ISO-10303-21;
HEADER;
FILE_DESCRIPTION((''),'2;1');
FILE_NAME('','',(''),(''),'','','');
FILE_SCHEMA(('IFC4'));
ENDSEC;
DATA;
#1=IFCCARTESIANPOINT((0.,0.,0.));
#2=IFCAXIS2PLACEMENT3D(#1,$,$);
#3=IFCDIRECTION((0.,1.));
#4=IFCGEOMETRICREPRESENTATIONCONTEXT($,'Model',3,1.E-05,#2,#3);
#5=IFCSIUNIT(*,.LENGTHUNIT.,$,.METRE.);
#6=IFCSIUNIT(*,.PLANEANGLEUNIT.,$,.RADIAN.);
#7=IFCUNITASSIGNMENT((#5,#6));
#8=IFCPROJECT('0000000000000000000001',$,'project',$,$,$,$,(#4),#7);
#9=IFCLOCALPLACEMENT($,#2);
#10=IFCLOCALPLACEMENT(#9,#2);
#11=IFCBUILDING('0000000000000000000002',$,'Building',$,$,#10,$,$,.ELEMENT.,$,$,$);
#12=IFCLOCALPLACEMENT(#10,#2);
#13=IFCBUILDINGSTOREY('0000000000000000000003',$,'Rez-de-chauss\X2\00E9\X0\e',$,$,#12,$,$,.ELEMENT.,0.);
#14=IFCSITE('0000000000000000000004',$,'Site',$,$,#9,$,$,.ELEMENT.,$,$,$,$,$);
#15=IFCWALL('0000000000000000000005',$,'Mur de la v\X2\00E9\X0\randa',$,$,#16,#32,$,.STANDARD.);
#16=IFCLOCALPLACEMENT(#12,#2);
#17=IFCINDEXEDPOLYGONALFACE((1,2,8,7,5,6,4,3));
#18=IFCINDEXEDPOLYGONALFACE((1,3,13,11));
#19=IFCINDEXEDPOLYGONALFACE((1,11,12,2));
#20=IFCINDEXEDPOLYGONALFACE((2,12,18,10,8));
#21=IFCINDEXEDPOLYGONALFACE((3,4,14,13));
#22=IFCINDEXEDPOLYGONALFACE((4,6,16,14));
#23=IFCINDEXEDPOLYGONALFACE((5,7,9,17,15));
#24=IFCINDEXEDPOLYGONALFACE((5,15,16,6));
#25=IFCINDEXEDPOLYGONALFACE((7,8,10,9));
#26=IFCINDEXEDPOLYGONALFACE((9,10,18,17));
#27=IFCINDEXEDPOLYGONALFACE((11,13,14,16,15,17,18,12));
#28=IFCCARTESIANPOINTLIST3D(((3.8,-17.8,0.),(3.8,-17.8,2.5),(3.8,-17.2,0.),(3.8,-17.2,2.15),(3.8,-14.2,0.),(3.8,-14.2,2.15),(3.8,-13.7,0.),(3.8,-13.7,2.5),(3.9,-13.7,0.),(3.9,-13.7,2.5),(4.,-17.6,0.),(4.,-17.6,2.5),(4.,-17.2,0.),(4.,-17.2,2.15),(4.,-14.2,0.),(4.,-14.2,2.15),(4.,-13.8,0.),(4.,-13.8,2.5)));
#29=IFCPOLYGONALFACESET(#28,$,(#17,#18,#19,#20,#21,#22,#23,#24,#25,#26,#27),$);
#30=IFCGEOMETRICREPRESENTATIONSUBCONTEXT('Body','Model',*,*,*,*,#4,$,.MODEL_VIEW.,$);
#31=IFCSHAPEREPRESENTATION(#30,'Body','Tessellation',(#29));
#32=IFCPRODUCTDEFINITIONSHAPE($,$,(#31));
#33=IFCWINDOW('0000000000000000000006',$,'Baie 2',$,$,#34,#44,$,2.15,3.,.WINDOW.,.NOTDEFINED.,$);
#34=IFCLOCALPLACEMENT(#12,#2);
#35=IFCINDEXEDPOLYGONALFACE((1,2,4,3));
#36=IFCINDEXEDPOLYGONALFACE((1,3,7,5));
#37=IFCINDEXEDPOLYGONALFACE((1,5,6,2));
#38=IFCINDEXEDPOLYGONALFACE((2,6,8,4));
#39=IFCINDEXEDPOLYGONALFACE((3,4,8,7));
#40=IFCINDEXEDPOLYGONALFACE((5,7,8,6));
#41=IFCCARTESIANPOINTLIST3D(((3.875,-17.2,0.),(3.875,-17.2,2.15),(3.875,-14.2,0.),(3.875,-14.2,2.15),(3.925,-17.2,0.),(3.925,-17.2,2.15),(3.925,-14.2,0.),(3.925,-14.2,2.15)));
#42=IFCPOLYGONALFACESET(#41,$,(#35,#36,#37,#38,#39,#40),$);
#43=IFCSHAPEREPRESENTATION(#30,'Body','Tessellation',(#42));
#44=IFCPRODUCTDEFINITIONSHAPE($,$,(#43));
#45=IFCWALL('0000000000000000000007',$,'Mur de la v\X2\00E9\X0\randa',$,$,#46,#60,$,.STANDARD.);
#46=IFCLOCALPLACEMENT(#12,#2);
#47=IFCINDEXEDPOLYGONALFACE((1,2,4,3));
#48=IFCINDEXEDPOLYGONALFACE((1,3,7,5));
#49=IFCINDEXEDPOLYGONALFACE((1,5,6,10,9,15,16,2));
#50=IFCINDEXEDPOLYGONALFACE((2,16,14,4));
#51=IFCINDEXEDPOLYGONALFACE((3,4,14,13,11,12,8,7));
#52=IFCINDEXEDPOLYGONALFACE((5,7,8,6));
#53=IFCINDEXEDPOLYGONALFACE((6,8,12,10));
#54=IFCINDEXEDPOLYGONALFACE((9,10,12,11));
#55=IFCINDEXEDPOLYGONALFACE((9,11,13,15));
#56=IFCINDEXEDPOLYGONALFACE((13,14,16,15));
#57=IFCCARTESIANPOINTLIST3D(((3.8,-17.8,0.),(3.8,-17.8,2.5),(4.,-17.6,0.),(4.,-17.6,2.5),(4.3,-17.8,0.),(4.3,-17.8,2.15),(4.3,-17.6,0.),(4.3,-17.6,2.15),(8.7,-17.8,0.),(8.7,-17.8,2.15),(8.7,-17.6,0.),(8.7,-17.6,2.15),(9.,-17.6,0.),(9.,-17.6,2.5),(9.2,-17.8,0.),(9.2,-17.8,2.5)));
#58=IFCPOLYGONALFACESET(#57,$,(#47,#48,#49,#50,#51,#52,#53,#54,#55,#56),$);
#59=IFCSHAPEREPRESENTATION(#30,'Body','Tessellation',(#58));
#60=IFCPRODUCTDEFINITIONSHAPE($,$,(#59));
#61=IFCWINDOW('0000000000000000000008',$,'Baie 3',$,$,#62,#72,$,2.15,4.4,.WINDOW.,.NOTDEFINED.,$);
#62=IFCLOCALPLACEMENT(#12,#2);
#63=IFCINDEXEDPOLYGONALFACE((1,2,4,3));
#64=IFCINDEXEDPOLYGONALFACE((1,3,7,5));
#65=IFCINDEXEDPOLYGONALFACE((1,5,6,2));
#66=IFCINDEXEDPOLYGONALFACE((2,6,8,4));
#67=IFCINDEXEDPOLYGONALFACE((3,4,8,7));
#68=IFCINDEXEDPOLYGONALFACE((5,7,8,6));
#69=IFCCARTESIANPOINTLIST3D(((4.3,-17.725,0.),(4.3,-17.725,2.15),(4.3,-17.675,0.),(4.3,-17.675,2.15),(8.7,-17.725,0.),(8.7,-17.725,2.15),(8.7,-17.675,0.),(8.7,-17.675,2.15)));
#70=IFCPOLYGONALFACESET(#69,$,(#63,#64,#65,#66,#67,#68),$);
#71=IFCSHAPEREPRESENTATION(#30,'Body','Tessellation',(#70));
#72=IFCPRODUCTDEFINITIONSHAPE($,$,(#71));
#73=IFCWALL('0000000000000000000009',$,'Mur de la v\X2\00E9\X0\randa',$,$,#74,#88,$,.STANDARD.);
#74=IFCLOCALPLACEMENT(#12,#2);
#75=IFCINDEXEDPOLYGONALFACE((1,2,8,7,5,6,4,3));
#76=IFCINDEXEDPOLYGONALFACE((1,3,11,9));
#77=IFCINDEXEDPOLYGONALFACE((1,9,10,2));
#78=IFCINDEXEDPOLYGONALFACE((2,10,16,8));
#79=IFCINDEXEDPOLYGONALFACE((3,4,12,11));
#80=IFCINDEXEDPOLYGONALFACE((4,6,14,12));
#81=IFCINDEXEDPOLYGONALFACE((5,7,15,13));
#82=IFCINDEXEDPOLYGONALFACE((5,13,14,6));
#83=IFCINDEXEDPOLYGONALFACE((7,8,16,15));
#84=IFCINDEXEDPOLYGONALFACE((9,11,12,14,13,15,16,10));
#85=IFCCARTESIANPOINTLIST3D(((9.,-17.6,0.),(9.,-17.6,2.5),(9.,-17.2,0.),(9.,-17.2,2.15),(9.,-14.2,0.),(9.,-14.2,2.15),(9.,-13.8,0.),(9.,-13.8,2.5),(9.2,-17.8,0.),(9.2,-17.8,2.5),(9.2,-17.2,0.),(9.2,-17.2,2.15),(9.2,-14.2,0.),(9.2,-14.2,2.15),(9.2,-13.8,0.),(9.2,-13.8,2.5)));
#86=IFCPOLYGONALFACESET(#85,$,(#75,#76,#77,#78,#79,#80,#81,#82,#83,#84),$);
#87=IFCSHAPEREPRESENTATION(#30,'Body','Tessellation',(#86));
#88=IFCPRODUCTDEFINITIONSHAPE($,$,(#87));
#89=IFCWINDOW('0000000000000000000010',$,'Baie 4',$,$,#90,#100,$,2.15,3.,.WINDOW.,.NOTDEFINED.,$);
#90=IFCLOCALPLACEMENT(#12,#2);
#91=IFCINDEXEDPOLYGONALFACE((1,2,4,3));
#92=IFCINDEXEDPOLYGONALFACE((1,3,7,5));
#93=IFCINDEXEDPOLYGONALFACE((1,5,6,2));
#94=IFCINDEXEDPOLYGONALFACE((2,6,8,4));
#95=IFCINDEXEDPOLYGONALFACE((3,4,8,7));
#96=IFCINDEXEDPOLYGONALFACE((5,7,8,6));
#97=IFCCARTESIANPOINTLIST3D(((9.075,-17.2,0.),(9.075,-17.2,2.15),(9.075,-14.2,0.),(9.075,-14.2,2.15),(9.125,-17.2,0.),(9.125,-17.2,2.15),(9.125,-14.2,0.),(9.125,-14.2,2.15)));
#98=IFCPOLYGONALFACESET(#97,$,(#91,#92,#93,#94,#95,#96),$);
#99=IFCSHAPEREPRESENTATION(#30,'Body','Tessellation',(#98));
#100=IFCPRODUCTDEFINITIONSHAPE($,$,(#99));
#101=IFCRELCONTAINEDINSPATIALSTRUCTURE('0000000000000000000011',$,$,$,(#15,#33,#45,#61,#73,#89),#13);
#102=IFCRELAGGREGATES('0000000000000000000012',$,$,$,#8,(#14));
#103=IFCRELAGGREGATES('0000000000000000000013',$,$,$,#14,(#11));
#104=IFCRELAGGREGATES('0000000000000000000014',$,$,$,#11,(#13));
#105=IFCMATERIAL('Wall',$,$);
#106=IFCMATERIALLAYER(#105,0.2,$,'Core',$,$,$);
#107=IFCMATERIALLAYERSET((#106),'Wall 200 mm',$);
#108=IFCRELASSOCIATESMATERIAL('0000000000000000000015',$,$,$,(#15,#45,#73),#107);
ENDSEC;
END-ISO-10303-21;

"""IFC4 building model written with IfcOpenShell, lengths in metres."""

from ifc_helpers import new_model, si_unit, direction, frame, origin, origin_2d, place, context, subcontext, project, spatial, polyline, rectangle, outline, extrude, material, layer, layer_set, layer_usage, element, fill, save


model = new_model("IFC4")

# Units and contexts
model_context = context("Model", 3, precision=1e-05, world=origin(), true_north=direction((0.0, 1.0)))
body_context = subcontext(model_context, "Body", "Model", "MODEL_VIEW")
ifc_project = project(units=[si_unit("LENGTHUNIT", "METRE"), si_unit("PLANEANGLEUNIT", "RADIAN")], contexts=[model_context])

# Site, building, storey
site_placement = place(None, origin())
site = spatial("IfcSite", under=ifc_project, at=site_placement, Name="Site", CompositionType="ELEMENT")
building_placement = place(site_placement, origin())
building = spatial("IfcBuilding", under=site, at=building_placement, Name="Building", CompositionType="ELEMENT")
storey_placement = place(building_placement, origin())
storey = spatial("IfcBuildingStorey", under=building, at=storey_placement, Name="Rez-de-chaussée", CompositionType="ELEMENT", Elevation=0.0)

# Shared definitions
ifc_material = material(Name="Wall")
ifc_layer = layer(ifc_material, 0.2, Name="Core")
ifc_layer_set = layer_set([ifc_layer], Name="Wall 200 mm")
ifc_layer_usage = layer_usage(ifc_layer_set, "AXIS2", "POSITIVE", -0.1)

# Walls, openings, windows
wall_1_placement = place(storey_placement, frame((3.9, -13.7, 0.0), z_axis=(0.0, 0.0, 1.0), x_axis=(0.0, -1.0, 0.0)))
wall_1 = element("IfcWall", 1, at=wall_1_placement, inside=storey, material=ifc_layer_usage, Name="Mur de la véranda", PredefinedType="STANDARD", context=body_context, shape_type="SweptSolid", body=[
    extrude(outline(polyline([(0.0, 0.0), (0.0, -0.1), (4.1, -0.1), (4.0, 0.0), (3.9, 0.1), (0.1, 0.1), (0.0, 0.0)])), origin(), (0.0, 0.0, 1.0), 2.5),
])
opening_1_placement = place(wall_1_placement, frame((2.0, 0.0, 0.0)))
opening_1 = element("IfcOpeningElement", 2, at=opening_1_placement, cuts=wall_1, PredefinedType="OPENING", context=body_context, shape_type="SweptSolid", body=[
    extrude(rectangle(XDim=3.0, YDim=0.4, at=origin_2d()), origin(), (0.0, 0.0, 1.0), 2.15),
])
window_1_placement = place(opening_1_placement, origin())
window_1 = element("IfcWindow", 3, at=window_1_placement, inside=storey, Name="Baie 2", OverallHeight=2.15, OverallWidth=3.0, PartitioningType="NOTDEFINED", PredefinedType="WINDOW", context=body_context, shape_type="SweptSolid", body=[
    extrude(rectangle(XDim=3.0, YDim=0.05, at=origin_2d()), origin(), (0.0, 0.0, 1.0), 2.15),
])
fill(opening_1, window_1)
wall_2_placement = place(storey_placement, frame((3.9, -17.7, 0.0)))
wall_2 = element("IfcWall", 4, at=wall_2_placement, inside=storey, material=ifc_layer_usage, Name="Mur de la véranda", PredefinedType="STANDARD", context=body_context, shape_type="SweptSolid", body=[
    extrude(outline(polyline([(0.0, 0.0), (-0.1, -0.1), (5.3, -0.1), (5.2, 0.0), (5.1, 0.1), (0.1, 0.1), (0.0, 0.0)])), origin(), (0.0, 0.0, 1.0), 2.5),
])
opening_2_placement = place(wall_2_placement, frame((2.6, 0.0, 0.0)))
opening_2 = element("IfcOpeningElement", 5, at=opening_2_placement, cuts=wall_2, PredefinedType="OPENING", context=body_context, shape_type="SweptSolid", body=[
    extrude(rectangle(XDim=4.4, YDim=0.4, at=origin_2d()), origin(), (0.0, 0.0, 1.0), 2.15),
])
window_2_placement = place(opening_2_placement, origin())
window_2 = element("IfcWindow", 6, at=window_2_placement, inside=storey, Name="Baie 3", OverallHeight=2.15, OverallWidth=4.4, PartitioningType="NOTDEFINED", PredefinedType="WINDOW", context=body_context, shape_type="SweptSolid", body=[
    extrude(rectangle(XDim=4.4, YDim=0.05, at=origin_2d()), origin(), (0.0, 0.0, 1.0), 2.15),
])
fill(opening_2, window_2)
wall_3_placement = place(storey_placement, frame((9.1, -17.7, 0.0), z_axis=(0.0, 0.0, 1.0), x_axis=(0.0, 1.0, 0.0)))
wall_3 = element("IfcWall", 7, at=wall_3_placement, inside=storey, material=ifc_layer_usage, Name="Mur de la véranda", PredefinedType="STANDARD", context=body_context, shape_type="SweptSolid", body=[
    extrude(outline(polyline([(0.0, 0.0), (-0.1, -0.1), (3.9, -0.1), (3.9, 0.0), (3.9, 0.1), (0.1, 0.1), (0.0, 0.0)])), origin(), (0.0, 0.0, 1.0), 2.5),
])
opening_3_placement = place(wall_3_placement, frame((2.0, 0.0, 0.0)))
opening_3 = element("IfcOpeningElement", 8, at=opening_3_placement, cuts=wall_3, PredefinedType="OPENING", context=body_context, shape_type="SweptSolid", body=[
    extrude(rectangle(XDim=3.0, YDim=0.4, at=origin_2d()), origin(), (0.0, 0.0, 1.0), 2.15),
])
window_3_placement = place(opening_3_placement, origin())
window_3 = element("IfcWindow", 9, at=window_3_placement, inside=storey, Name="Baie 4", OverallHeight=2.15, OverallWidth=3.0, PartitioningType="NOTDEFINED", PredefinedType="WINDOW", context=body_context, shape_type="SweptSolid", body=[
    extrude(rectangle(XDim=3.0, YDim=0.05, at=origin_2d()), origin(), (0.0, 0.0, 1.0), 2.15),
])
fill(opening_3, window_3)

save(model, "model.ifc")
